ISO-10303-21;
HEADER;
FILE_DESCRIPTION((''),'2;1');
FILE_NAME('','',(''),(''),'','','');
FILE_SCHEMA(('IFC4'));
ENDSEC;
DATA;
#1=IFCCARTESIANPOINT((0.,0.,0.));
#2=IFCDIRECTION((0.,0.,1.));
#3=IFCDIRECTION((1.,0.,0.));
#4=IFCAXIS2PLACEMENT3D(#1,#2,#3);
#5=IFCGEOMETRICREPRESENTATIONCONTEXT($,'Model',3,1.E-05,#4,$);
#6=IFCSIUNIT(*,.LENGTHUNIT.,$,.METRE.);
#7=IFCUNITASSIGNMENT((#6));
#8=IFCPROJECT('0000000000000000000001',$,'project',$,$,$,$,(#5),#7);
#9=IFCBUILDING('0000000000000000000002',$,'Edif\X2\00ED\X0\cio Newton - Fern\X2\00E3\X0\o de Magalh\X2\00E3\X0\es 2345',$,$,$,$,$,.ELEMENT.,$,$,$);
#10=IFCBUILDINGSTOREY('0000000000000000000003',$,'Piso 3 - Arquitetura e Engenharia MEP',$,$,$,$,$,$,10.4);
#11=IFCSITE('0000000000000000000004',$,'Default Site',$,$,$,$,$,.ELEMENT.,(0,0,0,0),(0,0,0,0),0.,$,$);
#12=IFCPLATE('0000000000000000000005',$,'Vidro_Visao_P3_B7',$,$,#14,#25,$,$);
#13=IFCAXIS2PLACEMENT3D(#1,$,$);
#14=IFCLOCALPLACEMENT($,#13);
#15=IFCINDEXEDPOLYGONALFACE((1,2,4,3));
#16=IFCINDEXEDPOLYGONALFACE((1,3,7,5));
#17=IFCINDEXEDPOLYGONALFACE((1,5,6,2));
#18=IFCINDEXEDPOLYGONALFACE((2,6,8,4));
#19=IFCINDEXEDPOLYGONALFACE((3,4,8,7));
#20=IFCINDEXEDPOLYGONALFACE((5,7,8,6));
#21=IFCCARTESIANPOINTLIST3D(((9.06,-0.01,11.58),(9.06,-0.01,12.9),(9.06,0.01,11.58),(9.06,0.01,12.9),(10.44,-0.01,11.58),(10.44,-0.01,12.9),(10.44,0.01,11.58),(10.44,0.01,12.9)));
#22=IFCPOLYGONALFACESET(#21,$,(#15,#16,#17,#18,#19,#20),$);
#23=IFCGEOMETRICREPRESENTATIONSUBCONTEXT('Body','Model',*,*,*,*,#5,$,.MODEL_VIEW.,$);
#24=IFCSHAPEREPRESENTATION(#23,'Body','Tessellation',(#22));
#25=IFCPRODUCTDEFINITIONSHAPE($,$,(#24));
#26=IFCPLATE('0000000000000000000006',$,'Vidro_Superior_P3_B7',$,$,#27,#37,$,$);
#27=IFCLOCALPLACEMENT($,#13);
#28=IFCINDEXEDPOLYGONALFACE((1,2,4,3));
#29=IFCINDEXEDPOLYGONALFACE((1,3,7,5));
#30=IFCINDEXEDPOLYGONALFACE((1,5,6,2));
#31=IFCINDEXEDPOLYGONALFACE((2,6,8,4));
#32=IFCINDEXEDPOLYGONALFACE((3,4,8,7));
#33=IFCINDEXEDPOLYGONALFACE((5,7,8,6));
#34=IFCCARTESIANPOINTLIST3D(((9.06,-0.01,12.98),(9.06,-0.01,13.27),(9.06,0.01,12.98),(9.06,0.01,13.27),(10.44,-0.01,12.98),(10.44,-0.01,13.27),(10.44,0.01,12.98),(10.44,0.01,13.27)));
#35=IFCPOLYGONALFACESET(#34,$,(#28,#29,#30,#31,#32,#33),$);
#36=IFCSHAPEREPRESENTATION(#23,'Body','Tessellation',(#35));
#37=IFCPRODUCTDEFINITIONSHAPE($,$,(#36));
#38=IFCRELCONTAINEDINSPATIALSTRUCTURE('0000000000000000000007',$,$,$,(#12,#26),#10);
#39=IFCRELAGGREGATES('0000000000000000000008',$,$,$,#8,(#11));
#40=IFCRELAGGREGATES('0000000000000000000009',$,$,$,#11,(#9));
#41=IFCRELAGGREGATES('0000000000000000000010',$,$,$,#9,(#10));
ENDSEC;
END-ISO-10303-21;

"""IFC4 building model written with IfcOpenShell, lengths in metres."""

from ifc_helpers import new_model, si_unit, frame, frame_2d, origin_with_axes, place, context, subcontext, project, spatial, rectangle, extrude, element, save


model = new_model("IFC4")

# Units and contexts
model_context = context("Model", 3, precision=1e-05, world=origin_with_axes())
body_context = subcontext(model_context, "Body", "Model", "MODEL_VIEW")
ifc_project = project(units=[si_unit("LENGTHUNIT", "METRE")], contexts=[model_context])

# Site, building, storey
site = spatial("IfcSite", under=ifc_project, Name="Default Site", CompositionType="ELEMENT", RefLatitude=(0, 0, 0, 0), RefLongitude=(0, 0, 0, 0), RefElevation=0.0)
building = spatial("IfcBuilding", under=site, Name="Edifício Newton - Fernão de Magalhães 2345", CompositionType="ELEMENT")
storey = spatial("IfcBuildingStorey", under=building, Name="Piso 3 - Arquitetura e Engenharia MEP", Elevation=10.4)

# Plates
plate_1_placement = place(None, frame((9.06, -0.01, 11.58), z_axis=(0.0, 0.0, 1.0), x_axis=(1.0, 0.0, 0.0)))
element("IfcPlate", 1, at=plate_1_placement, inside=storey, Name="Vidro_Visao_P3_B7", context=body_context, shape_type="SweptSolid", body=[
    extrude(rectangle(XDim=1.38, YDim=0.02, at=frame_2d((0.69, 0.01))), origin_with_axes(), (0.0, 0.0, 1.0), 1.32),
])
plate_2_placement = place(None, frame((9.06, -0.01, 12.98), z_axis=(0.0, 0.0, 1.0), x_axis=(1.0, 0.0, 0.0)))
element("IfcPlate", 2, at=plate_2_placement, inside=storey, Name="Vidro_Superior_P3_B7", context=body_context, shape_type="SweptSolid", body=[
    extrude(rectangle(XDim=1.38, YDim=0.02, at=frame_2d((0.69, 0.01))), origin_with_axes(), (0.0, 0.0, 1.0), 0.29),
])

save(model, "model.ifc")
